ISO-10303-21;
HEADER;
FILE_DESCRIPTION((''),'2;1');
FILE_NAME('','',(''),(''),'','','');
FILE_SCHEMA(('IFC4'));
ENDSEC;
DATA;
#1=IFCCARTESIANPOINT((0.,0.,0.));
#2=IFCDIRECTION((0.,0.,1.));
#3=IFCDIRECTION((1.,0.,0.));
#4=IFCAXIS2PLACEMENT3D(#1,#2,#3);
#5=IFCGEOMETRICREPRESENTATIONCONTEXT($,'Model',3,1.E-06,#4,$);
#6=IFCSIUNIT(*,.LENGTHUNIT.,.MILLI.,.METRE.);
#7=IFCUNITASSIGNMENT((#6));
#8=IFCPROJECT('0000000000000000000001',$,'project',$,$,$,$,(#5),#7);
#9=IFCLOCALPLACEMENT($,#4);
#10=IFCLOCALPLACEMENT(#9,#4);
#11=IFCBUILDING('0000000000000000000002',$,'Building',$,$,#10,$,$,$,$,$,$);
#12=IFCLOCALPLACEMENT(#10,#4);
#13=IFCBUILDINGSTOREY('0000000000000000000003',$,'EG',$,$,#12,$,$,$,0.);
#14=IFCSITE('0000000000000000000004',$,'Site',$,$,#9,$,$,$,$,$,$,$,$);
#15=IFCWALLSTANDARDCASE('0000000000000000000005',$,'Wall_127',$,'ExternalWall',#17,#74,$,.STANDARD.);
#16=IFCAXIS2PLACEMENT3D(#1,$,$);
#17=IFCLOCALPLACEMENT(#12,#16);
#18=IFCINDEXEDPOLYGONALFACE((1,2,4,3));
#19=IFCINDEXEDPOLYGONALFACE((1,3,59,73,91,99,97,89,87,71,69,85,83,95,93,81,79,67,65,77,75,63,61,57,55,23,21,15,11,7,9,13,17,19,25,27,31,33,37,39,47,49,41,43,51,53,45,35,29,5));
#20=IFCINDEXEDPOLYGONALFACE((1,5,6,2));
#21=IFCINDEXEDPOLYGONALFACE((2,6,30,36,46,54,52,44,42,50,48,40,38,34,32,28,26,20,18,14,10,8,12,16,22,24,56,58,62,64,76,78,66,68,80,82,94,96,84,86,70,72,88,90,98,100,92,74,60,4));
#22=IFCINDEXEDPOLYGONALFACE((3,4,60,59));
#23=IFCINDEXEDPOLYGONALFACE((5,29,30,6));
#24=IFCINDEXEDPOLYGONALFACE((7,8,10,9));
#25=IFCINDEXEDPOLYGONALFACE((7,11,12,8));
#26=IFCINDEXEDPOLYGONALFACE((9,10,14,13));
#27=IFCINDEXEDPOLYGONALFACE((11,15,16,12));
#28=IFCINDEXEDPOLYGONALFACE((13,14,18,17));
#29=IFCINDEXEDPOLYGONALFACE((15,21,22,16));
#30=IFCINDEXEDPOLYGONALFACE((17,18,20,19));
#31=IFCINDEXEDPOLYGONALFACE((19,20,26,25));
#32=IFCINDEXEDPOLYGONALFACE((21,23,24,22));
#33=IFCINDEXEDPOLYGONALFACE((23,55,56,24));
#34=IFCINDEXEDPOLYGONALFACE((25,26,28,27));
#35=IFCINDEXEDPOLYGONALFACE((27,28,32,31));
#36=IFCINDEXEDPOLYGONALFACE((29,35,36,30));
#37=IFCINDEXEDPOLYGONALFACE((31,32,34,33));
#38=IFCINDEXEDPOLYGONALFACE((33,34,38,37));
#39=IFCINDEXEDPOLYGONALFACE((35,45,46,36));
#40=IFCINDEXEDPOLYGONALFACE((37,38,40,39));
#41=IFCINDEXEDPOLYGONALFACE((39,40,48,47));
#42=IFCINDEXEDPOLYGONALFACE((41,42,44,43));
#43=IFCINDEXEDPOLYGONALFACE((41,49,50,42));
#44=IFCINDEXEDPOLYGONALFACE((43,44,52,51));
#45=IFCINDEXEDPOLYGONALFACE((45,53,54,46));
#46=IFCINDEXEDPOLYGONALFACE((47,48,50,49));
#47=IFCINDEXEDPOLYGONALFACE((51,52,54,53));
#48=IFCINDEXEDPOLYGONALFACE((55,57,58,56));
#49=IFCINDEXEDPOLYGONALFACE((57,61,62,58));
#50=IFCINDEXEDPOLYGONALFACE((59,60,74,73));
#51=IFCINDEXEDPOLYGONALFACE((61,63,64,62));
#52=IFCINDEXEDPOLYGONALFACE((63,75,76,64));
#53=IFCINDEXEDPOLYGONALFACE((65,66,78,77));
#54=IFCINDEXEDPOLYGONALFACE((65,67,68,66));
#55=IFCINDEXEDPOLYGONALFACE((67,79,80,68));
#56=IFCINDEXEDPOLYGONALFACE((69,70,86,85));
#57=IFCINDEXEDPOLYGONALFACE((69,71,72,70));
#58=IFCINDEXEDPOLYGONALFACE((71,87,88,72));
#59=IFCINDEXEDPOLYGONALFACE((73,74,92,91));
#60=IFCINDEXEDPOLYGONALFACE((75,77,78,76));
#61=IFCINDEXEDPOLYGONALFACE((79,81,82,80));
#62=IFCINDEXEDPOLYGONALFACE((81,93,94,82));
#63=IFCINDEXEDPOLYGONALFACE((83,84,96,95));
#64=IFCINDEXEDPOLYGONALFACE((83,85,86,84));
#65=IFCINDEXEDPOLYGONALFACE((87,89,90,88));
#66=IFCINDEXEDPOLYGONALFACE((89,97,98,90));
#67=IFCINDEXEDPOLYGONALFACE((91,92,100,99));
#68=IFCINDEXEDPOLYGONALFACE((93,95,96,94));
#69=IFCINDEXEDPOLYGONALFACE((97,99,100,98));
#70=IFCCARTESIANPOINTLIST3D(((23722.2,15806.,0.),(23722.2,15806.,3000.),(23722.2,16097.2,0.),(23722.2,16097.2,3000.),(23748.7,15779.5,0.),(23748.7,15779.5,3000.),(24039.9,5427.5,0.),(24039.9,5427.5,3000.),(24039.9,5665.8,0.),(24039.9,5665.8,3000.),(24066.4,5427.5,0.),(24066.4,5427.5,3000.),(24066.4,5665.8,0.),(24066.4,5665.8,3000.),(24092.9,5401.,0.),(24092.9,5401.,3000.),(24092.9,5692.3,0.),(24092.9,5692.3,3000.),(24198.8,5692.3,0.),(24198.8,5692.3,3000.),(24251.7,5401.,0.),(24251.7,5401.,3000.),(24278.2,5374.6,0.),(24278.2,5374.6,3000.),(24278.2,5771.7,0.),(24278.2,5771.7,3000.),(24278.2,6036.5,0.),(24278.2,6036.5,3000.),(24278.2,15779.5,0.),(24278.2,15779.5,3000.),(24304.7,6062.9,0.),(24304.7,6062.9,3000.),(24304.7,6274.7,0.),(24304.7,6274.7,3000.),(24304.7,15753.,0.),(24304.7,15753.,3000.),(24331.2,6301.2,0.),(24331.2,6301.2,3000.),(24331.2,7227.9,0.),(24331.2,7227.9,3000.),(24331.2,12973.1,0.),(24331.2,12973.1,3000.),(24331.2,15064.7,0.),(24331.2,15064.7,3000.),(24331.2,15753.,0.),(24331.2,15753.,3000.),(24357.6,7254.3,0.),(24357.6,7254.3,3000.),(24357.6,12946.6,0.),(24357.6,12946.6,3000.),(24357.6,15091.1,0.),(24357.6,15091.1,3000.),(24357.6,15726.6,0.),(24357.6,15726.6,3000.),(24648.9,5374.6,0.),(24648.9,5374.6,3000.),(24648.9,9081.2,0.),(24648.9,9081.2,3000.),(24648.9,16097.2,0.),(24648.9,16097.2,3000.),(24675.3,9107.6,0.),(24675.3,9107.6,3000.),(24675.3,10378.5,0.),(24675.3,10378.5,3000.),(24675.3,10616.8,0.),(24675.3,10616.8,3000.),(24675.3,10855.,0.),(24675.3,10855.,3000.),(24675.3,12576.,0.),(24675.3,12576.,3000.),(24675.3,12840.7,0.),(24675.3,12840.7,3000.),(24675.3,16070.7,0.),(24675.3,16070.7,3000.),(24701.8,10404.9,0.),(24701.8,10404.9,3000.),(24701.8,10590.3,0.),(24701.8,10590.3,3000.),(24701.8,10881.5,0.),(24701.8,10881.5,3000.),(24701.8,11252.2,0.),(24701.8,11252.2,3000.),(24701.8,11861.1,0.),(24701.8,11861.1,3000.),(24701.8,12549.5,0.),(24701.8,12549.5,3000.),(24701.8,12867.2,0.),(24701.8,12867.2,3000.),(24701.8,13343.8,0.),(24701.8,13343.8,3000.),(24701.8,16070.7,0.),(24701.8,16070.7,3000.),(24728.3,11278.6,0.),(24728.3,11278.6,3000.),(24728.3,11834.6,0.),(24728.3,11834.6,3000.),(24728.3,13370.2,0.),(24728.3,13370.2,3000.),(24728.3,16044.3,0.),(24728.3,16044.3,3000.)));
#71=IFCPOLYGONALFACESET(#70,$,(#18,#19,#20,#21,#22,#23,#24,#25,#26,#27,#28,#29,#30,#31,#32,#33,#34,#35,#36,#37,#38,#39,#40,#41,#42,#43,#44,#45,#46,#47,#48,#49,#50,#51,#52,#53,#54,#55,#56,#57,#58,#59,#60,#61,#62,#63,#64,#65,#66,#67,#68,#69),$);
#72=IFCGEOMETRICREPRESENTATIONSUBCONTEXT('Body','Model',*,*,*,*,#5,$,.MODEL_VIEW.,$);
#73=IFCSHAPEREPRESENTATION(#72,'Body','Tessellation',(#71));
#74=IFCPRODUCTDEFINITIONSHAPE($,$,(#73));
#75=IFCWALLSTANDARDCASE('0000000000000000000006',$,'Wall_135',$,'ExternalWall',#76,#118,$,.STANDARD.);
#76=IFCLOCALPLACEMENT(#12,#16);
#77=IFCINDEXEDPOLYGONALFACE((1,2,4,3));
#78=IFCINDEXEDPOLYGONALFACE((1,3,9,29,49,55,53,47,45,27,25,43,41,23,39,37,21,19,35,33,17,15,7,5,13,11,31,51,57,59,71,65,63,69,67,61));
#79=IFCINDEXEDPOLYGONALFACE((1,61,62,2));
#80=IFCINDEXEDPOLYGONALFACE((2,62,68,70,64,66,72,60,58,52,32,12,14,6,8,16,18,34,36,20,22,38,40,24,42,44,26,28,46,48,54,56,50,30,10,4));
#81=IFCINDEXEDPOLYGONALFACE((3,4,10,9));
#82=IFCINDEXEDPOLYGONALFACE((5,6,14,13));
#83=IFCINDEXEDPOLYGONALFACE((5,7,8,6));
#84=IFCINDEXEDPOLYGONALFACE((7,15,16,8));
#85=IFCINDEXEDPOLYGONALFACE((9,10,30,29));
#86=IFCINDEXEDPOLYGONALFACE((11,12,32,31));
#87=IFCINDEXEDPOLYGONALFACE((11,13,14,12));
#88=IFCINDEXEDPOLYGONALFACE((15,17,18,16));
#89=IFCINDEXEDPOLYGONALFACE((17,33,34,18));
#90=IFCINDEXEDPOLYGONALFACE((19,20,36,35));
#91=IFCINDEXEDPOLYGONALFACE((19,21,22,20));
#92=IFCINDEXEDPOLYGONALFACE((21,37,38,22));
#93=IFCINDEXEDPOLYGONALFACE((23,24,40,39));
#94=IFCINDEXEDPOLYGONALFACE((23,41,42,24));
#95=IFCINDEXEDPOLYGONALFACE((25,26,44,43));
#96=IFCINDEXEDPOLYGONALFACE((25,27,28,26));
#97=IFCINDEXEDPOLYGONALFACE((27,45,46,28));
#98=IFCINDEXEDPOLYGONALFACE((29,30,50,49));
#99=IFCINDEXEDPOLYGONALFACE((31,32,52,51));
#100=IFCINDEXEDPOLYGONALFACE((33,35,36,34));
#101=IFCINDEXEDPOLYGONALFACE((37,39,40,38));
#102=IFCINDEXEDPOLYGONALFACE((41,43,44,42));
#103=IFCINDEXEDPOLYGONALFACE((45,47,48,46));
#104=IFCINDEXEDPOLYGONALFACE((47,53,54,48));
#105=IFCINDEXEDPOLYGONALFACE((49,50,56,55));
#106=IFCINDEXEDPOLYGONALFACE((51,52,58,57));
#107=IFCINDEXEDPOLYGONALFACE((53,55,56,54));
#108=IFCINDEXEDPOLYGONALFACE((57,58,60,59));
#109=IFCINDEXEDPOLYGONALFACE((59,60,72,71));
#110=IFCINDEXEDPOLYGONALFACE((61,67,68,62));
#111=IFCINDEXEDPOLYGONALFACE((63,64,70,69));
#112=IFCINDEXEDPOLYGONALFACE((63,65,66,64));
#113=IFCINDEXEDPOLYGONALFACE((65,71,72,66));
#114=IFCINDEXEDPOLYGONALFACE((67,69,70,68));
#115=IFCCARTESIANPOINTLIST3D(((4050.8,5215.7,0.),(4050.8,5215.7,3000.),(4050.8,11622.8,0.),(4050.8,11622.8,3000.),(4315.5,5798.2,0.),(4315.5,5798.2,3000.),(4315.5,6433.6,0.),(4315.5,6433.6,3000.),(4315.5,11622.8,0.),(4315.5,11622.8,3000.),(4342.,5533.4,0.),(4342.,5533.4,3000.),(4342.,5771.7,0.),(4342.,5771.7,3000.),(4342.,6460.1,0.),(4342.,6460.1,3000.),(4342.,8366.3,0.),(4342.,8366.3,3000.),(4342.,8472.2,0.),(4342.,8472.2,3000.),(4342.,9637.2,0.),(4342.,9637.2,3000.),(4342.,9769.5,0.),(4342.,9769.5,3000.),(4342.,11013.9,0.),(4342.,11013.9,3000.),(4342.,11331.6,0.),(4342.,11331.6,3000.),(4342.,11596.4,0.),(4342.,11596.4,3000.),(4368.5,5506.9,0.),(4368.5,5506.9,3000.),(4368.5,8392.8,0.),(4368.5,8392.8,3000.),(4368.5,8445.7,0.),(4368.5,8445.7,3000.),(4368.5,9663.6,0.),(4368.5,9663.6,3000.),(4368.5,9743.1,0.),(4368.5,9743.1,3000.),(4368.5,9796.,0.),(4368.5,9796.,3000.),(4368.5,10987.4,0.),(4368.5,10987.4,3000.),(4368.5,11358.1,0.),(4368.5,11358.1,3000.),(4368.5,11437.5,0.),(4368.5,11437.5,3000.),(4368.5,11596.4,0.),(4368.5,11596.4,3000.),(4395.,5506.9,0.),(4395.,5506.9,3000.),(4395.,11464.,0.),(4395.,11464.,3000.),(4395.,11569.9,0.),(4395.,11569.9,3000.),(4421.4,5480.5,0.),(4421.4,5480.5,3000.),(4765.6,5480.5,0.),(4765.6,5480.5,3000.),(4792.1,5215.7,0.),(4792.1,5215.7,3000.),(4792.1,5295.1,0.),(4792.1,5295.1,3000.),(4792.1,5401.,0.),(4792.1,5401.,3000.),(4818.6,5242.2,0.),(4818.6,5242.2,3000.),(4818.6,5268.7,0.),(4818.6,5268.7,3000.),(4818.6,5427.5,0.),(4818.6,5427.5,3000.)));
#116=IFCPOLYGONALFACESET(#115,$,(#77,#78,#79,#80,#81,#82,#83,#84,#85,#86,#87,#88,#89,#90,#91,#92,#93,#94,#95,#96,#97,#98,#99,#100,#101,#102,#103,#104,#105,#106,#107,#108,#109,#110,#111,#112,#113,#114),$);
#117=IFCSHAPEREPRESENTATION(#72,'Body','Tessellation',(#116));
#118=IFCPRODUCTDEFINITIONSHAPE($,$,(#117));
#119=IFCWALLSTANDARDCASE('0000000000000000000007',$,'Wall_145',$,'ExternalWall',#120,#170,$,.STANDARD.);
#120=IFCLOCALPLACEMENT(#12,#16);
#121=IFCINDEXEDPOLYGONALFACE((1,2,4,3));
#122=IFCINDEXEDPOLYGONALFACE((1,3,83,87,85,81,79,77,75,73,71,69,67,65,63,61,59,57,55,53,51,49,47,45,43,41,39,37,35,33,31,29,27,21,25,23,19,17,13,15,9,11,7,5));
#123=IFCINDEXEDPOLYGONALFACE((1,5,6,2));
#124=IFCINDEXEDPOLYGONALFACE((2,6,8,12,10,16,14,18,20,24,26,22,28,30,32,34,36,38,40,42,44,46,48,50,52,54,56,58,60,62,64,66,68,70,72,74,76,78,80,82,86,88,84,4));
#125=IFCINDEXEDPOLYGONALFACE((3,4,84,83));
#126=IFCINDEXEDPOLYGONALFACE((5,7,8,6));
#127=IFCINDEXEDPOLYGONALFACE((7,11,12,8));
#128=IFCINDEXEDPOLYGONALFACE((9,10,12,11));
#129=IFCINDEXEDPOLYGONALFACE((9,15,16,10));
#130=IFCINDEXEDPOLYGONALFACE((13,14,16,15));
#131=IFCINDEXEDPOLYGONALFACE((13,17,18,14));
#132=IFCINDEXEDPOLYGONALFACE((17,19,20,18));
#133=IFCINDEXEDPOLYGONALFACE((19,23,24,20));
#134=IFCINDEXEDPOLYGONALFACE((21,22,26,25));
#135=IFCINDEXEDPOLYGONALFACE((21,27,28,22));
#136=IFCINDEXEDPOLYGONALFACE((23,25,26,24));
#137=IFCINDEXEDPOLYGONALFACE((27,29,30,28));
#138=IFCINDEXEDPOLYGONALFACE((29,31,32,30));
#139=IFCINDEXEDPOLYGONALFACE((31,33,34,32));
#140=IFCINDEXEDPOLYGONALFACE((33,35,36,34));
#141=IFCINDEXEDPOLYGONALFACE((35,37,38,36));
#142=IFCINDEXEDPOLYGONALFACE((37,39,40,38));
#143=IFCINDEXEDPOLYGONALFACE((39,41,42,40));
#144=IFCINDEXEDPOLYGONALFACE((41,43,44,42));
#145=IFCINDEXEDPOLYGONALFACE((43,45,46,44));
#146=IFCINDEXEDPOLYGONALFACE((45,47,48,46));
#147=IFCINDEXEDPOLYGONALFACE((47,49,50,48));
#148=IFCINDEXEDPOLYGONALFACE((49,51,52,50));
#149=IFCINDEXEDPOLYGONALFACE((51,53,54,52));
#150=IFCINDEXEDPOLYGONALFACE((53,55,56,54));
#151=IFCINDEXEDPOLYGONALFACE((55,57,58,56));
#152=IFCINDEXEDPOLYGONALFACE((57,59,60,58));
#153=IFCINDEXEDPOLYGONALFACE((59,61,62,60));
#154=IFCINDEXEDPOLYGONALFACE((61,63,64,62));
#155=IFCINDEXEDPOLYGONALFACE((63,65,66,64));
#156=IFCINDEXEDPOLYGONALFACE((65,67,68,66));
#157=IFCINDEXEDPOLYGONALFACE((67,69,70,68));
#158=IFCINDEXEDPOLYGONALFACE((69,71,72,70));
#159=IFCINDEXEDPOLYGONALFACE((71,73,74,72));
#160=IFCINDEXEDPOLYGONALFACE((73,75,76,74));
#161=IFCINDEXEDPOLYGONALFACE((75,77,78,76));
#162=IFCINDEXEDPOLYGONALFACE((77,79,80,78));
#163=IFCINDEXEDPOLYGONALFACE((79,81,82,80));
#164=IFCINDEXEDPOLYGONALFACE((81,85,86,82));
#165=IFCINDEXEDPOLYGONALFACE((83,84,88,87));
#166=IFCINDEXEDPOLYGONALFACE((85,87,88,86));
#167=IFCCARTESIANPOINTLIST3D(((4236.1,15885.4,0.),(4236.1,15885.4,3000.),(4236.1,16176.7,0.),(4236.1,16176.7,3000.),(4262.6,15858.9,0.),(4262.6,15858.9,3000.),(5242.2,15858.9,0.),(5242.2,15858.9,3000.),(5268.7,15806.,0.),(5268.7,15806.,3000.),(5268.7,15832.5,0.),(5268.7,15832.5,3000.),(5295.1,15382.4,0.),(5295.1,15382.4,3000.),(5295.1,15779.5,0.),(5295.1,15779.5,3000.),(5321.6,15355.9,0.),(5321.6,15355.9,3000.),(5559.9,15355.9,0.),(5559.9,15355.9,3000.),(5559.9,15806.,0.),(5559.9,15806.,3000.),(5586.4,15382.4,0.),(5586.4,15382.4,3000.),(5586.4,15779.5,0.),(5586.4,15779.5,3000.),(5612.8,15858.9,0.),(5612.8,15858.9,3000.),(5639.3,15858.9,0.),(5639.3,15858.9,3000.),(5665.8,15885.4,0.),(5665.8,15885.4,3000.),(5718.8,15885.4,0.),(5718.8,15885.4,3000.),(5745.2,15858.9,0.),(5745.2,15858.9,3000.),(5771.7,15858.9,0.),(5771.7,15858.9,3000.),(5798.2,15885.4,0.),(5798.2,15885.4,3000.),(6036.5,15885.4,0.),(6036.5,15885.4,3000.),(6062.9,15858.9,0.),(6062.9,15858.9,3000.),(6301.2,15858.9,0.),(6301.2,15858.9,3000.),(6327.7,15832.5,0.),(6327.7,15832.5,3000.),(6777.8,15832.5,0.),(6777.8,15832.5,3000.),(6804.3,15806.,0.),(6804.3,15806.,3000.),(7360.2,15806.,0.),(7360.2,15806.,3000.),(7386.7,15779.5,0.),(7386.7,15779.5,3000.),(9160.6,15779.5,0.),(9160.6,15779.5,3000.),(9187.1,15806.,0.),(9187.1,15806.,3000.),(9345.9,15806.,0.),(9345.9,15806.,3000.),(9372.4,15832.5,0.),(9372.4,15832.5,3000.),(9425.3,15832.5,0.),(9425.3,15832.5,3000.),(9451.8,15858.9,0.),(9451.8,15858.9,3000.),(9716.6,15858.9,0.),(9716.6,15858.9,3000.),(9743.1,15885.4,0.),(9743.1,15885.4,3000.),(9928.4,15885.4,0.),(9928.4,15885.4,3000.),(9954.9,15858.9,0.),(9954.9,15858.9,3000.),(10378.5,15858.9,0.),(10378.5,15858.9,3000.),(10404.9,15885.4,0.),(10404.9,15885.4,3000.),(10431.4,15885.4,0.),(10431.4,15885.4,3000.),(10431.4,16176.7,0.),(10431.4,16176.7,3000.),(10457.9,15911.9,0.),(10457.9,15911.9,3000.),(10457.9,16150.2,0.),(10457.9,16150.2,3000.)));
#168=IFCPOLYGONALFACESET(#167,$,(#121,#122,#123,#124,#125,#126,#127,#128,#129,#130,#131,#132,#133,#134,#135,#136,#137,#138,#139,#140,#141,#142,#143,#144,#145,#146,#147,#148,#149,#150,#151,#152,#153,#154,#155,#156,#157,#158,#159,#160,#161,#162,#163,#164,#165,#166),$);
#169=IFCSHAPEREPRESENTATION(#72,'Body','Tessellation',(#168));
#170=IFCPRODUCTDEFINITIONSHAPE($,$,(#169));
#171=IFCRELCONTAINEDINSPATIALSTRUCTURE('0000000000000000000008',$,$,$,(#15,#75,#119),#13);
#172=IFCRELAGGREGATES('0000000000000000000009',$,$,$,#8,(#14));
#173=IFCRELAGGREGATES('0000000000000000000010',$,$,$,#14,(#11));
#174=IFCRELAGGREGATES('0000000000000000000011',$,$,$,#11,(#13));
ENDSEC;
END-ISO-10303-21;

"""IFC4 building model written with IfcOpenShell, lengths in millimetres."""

from ifc_helpers import new_model, si_unit, frame, origin_with_axes, place, context, subcontext, project, spatial, polyline, outline, extrude, element, save


model = new_model("IFC4")

# Units and contexts
model_context = context("Model", 3, precision=1e-06, world=origin_with_axes())
body_context = subcontext(model_context, "Body", "Model", "MODEL_VIEW")
ifc_project = project(units=[si_unit("LENGTHUNIT", "METRE", prefix="MILLI")], contexts=[model_context])

# Site, building, storey
site_placement = place(None, origin_with_axes())
site = spatial("IfcSite", under=ifc_project, at=site_placement, Name="Site")
building_placement = place(site_placement, origin_with_axes())
building = spatial("IfcBuilding", under=site, at=building_placement, Name="Building")
storey_placement = place(building_placement, origin_with_axes())
storey = spatial("IfcBuildingStorey", under=building, at=storey_placement, Name="EG", Elevation=0.0)

# Walls
wall_1_placement = place(storey_placement, origin_with_axes())
element("IfcWallStandardCase", 1, at=wall_1_placement, inside=storey, Name="Wall_127", ObjectType="ExternalWall", PredefinedType="STANDARD", context=body_context, shape_type="SweptSolid", body=[
    extrude(outline(polyline([(24278.2, 5374.6, 0.0), (24251.7, 5401.0, 0.0), (24092.9, 5401.0, 0.0), (24066.4, 5427.5, 0.0), (24039.9, 5427.5, 0.0), (24039.9, 5665.8, 0.0), (24066.4, 5665.8, 0.0), (24092.9, 5692.3, 0.0), (24198.8, 5692.3, 0.0), (24278.2, 5771.7, 0.0), (24278.2, 6036.5, 0.0), (24304.7, 6062.9, 0.0), (24304.7, 6274.7, 0.0), (24331.2, 6301.2, 0.0), (24331.2, 7227.9, 0.0), (24357.6, 7254.3, 0.0), (24357.6, 12946.6, 0.0), (24331.2, 12973.1, 0.0), (24331.2, 15064.7, 0.0), (24357.6, 15091.1, 0.0), (24357.6, 15726.6, 0.0), (24331.2, 15753.0, 0.0), (24304.7, 15753.0, 0.0), (24278.2, 15779.5, 0.0), (23748.7, 15779.5, 0.0), (23722.2, 15806.0, 0.0), (23722.2, 16097.2, 0.0), (24648.9, 16097.2, 0.0), (24675.3, 16070.7, 0.0), (24701.8, 16070.7, 0.0), (24728.3, 16044.3, 0.0), (24728.3, 13370.2, 0.0), (24701.8, 13343.8, 0.0), (24701.8, 12867.2, 0.0), (24675.3, 12840.7, 0.0), (24675.3, 12576.0, 0.0), (24701.8, 12549.5, 0.0), (24701.8, 11861.1, 0.0), (24728.3, 11834.6, 0.0), (24728.3, 11278.6, 0.0), (24701.8, 11252.2, 0.0), (24701.8, 10881.5, 0.0), (24675.3, 10855.0, 0.0), (24675.3, 10616.8, 0.0), (24701.8, 10590.3, 0.0), (24701.8, 10404.9, 0.0), (24675.3, 10378.5, 0.0), (24675.3, 9107.6, 0.0), (24648.9, 9081.2, 0.0), (24648.9, 5374.6, 0.0), (24278.2, 5374.6, 0.0)])), origin_with_axes(), (0.0, 0.0, 1.0), 3000.0),
])
for number, where, z_axis, x_axis, name in (
    (2, (0.0, 0.0, 0.0), (0.0, 0.0, 1.0), (1.0, 0.0, 0.0), "Wall_135"),
):
    element("IfcWallStandardCase", number, at=place(storey_placement, frame(where, z_axis=z_axis, x_axis=x_axis)), inside=storey, Name=name, ObjectType="ExternalWall", PredefinedType="STANDARD", context=body_context, shape_type="SweptSolid", body=[
        extrude(outline(polyline([(4050.8, 5215.7, 0.0), (4050.8, 11622.8, 0.0), (4315.5, 11622.8, 0.0), (4342.0, 11596.4, 0.0), (4368.5, 11596.4, 0.0), (4395.0, 11569.9, 0.0), (4395.0, 11464.0, 0.0), (4368.5, 11437.5, 0.0), (4368.5, 11358.1, 0.0), (4342.0, 11331.6, 0.0), (4342.0, 11013.9, 0.0), (4368.5, 10987.4, 0.0), (4368.5, 9796.0, 0.0), (4342.0, 9769.5, 0.0), (4368.5, 9743.1, 0.0), (4368.5, 9663.6, 0.0), (4342.0, 9637.2, 0.0), (4342.0, 8472.2, 0.0), (4368.5, 8445.7, 0.0), (4368.5, 8392.8, 0.0), (4342.0, 8366.3, 0.0), (4342.0, 6460.1, 0.0), (4315.5, 6433.6, 0.0), (4315.5, 5798.2, 0.0), (4342.0, 5771.7, 0.0), (4342.0, 5533.4, 0.0), (4368.5, 5506.9, 0.0), (4395.0, 5506.9, 0.0), (4421.4, 5480.5, 0.0), (4765.6, 5480.5, 0.0), (4818.6, 5427.5, 0.0), (4792.1, 5401.0, 0.0), (4792.1, 5295.1, 0.0), (4818.6, 5268.7, 0.0), (4818.6, 5242.2, 0.0), (4792.1, 5215.7, 0.0), (4050.8, 5215.7, 0.0)])), origin_with_axes(), (0.0, 0.0, 1.0), 3000.0),
    ])
wall_2_placement = place(storey_placement, origin_with_axes())
element("IfcWallStandardCase", 3, at=wall_2_placement, inside=storey, Name="Wall_145", ObjectType="ExternalWall", PredefinedType="STANDARD", context=body_context, shape_type="SweptSolid", body=[
    extrude(outline(polyline([(5321.6, 15355.9, 0.0), (5295.1, 15382.4, 0.0), (5295.1, 15779.5, 0.0), (5268.7, 15806.0, 0.0), (5268.7, 15832.5, 0.0), (5242.2, 15858.9, 0.0), (4262.6, 15858.9, 0.0), (4236.1, 15885.4, 0.0), (4236.1, 16176.7, 0.0), (10431.4, 16176.7, 0.0), (10457.9, 16150.2, 0.0), (10457.9, 15911.9, 0.0), (10431.4, 15885.4, 0.0), (10404.9, 15885.4, 0.0), (10378.5, 15858.9, 0.0), (9954.9, 15858.9, 0.0), (9928.4, 15885.4, 0.0), (9743.1, 15885.4, 0.0), (9716.6, 15858.9, 0.0), (9451.8, 15858.9, 0.0), (9425.3, 15832.5, 0.0), (9372.4, 15832.5, 0.0), (9345.9, 15806.0, 0.0), (9187.1, 15806.0, 0.0), (9160.6, 15779.5, 0.0), (7386.7, 15779.5, 0.0), (7360.2, 15806.0, 0.0), (6804.3, 15806.0, 0.0), (6777.8, 15832.5, 0.0), (6327.7, 15832.5, 0.0), (6301.2, 15858.9, 0.0), (6062.9, 15858.9, 0.0), (6036.5, 15885.4, 0.0), (5798.2, 15885.4, 0.0), (5771.7, 15858.9, 0.0), (5745.2, 15858.9, 0.0), (5718.8, 15885.4, 0.0), (5665.8, 15885.4, 0.0), (5639.3, 15858.9, 0.0), (5612.8, 15858.9, 0.0), (5559.9, 15806.0, 0.0), (5586.4, 15779.5, 0.0), (5586.4, 15382.4, 0.0), (5559.9, 15355.9, 0.0), (5321.6, 15355.9, 0.0)])), origin_with_axes(), (0.0, 0.0, 1.0), 3000.0),
])

save(model, "model.ifc")
